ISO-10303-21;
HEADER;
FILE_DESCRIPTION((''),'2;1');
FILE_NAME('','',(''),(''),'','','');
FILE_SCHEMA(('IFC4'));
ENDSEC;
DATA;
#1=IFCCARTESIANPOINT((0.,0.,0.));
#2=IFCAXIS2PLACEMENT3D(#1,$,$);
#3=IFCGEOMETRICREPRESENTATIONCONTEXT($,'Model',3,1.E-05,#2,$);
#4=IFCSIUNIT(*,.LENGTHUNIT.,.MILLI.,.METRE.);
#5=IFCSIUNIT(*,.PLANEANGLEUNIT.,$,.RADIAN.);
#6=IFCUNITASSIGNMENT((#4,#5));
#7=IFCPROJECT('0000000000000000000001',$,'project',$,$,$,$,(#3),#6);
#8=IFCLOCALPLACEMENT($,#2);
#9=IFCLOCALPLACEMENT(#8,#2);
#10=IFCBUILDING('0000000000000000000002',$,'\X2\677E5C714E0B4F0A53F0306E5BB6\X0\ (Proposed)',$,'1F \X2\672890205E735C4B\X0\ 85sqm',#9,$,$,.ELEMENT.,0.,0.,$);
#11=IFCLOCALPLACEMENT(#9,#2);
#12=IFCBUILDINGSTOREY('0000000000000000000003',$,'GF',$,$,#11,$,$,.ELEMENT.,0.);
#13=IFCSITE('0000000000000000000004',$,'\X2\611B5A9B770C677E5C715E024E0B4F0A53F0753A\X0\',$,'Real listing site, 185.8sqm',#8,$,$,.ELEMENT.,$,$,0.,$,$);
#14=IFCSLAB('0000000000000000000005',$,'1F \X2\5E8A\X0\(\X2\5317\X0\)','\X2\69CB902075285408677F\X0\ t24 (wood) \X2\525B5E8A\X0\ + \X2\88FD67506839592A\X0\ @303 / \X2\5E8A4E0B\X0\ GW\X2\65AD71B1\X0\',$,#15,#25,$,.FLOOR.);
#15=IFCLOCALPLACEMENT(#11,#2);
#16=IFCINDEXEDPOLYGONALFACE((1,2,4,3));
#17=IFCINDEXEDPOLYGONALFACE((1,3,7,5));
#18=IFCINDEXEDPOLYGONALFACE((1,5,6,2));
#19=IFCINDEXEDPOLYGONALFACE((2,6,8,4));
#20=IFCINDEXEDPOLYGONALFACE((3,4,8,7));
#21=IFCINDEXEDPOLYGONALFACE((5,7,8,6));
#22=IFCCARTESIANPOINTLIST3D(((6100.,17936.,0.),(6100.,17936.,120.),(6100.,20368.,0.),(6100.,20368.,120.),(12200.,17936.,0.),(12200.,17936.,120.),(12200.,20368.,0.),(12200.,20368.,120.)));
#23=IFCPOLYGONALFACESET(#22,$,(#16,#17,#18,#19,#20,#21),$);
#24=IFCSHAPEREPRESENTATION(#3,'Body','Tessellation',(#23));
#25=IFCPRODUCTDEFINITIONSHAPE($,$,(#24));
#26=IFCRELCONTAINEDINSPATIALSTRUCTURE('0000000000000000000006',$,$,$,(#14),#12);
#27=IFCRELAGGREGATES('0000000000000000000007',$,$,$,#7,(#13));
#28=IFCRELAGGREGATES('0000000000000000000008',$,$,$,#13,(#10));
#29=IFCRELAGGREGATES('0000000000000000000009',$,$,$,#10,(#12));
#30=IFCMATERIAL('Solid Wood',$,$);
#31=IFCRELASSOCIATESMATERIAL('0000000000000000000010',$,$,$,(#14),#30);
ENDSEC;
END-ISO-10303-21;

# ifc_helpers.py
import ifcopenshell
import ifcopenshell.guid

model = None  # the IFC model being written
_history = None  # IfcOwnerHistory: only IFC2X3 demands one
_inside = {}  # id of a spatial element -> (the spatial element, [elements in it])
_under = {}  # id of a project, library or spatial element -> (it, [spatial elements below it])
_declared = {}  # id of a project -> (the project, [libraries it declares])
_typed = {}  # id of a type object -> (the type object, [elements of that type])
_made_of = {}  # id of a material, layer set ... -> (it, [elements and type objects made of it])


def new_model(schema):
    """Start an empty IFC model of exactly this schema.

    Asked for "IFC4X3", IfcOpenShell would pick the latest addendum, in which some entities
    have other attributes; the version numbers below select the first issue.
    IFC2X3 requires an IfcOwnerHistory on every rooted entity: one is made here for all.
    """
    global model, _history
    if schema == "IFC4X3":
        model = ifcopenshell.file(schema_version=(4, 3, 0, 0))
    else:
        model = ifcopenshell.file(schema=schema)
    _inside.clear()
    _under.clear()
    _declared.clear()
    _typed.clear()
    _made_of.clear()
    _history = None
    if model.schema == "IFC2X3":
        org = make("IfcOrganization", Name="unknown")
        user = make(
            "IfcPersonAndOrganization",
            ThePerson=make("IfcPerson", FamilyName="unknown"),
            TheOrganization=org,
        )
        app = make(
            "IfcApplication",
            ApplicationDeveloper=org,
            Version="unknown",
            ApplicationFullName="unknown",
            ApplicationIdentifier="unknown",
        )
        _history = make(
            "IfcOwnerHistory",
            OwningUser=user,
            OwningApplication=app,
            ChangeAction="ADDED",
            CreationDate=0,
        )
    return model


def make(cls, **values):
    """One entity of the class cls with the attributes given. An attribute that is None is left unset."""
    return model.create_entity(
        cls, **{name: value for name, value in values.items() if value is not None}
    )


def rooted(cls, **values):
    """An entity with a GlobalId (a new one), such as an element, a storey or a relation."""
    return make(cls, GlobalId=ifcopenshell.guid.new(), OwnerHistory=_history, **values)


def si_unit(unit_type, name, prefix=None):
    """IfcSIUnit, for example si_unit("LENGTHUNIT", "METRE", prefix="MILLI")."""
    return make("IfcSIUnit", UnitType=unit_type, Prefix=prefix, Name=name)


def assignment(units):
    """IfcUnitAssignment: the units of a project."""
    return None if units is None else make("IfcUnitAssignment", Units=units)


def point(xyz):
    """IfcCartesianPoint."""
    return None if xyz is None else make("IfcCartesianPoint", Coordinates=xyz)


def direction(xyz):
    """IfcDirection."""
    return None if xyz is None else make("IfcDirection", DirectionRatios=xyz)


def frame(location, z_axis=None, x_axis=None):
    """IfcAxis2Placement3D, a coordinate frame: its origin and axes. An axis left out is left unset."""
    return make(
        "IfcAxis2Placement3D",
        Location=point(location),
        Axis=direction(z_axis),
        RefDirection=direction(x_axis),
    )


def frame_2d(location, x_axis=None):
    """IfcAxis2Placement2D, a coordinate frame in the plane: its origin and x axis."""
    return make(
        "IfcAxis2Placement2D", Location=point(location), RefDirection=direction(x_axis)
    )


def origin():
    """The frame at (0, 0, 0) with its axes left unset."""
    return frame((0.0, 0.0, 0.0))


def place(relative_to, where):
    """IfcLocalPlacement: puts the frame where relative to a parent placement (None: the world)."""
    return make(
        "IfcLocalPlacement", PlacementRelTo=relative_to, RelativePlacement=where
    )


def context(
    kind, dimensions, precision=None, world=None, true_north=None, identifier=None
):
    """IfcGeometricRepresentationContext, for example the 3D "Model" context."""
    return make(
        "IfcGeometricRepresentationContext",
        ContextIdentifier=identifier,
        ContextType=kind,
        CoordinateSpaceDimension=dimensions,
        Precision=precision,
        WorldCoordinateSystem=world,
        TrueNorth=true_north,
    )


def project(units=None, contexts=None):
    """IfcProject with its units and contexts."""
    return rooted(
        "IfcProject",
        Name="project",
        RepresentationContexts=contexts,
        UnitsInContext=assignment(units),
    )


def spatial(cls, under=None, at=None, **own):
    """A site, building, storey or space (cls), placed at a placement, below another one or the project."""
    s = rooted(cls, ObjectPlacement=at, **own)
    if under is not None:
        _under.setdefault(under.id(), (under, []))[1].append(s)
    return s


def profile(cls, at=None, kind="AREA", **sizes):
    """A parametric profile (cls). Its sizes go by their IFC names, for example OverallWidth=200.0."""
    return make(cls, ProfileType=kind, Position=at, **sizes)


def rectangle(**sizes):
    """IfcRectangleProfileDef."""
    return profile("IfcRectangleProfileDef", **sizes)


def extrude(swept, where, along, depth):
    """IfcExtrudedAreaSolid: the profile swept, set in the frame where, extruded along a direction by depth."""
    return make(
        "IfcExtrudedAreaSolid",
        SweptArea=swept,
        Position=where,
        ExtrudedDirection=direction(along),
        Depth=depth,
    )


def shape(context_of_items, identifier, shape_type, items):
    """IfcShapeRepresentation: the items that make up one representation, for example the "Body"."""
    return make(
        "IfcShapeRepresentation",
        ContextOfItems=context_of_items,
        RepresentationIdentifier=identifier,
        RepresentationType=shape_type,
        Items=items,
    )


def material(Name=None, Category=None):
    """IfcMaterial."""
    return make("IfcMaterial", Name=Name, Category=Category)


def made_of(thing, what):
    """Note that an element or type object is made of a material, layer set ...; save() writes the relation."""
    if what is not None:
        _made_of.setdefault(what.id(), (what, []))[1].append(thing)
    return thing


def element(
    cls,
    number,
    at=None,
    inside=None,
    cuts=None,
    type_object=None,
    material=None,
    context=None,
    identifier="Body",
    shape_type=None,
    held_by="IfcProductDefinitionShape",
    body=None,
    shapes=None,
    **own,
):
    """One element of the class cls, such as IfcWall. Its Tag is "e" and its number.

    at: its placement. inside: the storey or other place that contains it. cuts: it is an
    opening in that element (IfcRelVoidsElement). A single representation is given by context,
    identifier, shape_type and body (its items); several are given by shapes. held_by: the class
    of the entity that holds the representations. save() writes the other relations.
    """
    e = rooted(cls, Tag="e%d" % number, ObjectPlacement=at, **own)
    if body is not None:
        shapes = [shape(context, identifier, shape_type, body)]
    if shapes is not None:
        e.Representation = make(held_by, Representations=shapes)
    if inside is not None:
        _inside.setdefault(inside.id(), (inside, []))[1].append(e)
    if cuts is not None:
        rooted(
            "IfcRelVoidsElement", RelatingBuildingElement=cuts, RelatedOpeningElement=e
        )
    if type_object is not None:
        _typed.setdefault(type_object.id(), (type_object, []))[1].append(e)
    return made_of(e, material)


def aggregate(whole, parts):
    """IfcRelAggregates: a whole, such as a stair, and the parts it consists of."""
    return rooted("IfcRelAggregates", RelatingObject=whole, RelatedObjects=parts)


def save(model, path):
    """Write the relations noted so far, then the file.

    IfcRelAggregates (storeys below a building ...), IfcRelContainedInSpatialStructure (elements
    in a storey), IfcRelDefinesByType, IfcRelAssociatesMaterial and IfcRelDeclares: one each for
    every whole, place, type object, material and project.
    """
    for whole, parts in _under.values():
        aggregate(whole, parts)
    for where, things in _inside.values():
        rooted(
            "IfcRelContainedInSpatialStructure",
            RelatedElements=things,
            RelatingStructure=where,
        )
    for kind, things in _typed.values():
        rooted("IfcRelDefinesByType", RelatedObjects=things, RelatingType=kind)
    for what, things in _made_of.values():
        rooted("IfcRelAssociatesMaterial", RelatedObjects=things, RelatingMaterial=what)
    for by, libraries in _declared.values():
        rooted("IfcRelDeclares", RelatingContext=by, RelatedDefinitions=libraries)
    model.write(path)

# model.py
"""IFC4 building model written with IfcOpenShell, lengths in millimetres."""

from ifc_helpers import new_model, si_unit, frame, frame_2d, origin, place, context, project, spatial, rectangle, extrude, material, element, save


model = new_model("IFC4")

# Units and contexts
model_context = context("Model", 3, precision=1e-05, world=origin())
ifc_project = project(units=[si_unit("LENGTHUNIT", "METRE", prefix="MILLI"), si_unit("PLANEANGLEUNIT", "RADIAN")], contexts=[model_context])

# Site, building, storey
site_placement = place(None, origin())
site = spatial("IfcSite", under=ifc_project, at=site_placement, Name="愛媛県松山市下伊台町", ObjectType="Real listing site, 185.8sqm", CompositionType="ELEMENT", RefElevation=0.0)
building_placement = place(site_placement, origin())
building = spatial("IfcBuilding", under=site, at=building_placement, Name="松山下伊台の家 (Proposed)", ObjectType="1F 木造平屋 85sqm", CompositionType="ELEMENT", ElevationOfRefHeight=0.0, ElevationOfTerrain=0.0)
storey_placement = place(building_placement, origin())
storey = spatial("IfcBuildingStorey", under=building, at=storey_placement, Name="GF", CompositionType="ELEMENT", Elevation=0.0)

# Slab
ifc_material_1 = material(Name="Solid Wood")
slab_1_placement = place(storey_placement, frame((3050.0, 8968.0, 0.0)))
element("IfcSlab", 1, at=slab_1_placement, inside=storey, material=ifc_material_1, Name="1F 床(北)", Description="構造用合板 t24 (wood) 剛床 + 製材根太 @303 / 床下 GW断熱", PredefinedType="FLOOR", context=model_context, shape_type="SweptSolid", body=[
    extrude(rectangle(XDim=6100.0, YDim=2432.0, at=frame_2d((3050.0, 1216.0))), frame((3050.0, 8968.0, 0.0)), (0.0, 0.0, 1.0), 120.0),
])

save(model, "model.ifc")
